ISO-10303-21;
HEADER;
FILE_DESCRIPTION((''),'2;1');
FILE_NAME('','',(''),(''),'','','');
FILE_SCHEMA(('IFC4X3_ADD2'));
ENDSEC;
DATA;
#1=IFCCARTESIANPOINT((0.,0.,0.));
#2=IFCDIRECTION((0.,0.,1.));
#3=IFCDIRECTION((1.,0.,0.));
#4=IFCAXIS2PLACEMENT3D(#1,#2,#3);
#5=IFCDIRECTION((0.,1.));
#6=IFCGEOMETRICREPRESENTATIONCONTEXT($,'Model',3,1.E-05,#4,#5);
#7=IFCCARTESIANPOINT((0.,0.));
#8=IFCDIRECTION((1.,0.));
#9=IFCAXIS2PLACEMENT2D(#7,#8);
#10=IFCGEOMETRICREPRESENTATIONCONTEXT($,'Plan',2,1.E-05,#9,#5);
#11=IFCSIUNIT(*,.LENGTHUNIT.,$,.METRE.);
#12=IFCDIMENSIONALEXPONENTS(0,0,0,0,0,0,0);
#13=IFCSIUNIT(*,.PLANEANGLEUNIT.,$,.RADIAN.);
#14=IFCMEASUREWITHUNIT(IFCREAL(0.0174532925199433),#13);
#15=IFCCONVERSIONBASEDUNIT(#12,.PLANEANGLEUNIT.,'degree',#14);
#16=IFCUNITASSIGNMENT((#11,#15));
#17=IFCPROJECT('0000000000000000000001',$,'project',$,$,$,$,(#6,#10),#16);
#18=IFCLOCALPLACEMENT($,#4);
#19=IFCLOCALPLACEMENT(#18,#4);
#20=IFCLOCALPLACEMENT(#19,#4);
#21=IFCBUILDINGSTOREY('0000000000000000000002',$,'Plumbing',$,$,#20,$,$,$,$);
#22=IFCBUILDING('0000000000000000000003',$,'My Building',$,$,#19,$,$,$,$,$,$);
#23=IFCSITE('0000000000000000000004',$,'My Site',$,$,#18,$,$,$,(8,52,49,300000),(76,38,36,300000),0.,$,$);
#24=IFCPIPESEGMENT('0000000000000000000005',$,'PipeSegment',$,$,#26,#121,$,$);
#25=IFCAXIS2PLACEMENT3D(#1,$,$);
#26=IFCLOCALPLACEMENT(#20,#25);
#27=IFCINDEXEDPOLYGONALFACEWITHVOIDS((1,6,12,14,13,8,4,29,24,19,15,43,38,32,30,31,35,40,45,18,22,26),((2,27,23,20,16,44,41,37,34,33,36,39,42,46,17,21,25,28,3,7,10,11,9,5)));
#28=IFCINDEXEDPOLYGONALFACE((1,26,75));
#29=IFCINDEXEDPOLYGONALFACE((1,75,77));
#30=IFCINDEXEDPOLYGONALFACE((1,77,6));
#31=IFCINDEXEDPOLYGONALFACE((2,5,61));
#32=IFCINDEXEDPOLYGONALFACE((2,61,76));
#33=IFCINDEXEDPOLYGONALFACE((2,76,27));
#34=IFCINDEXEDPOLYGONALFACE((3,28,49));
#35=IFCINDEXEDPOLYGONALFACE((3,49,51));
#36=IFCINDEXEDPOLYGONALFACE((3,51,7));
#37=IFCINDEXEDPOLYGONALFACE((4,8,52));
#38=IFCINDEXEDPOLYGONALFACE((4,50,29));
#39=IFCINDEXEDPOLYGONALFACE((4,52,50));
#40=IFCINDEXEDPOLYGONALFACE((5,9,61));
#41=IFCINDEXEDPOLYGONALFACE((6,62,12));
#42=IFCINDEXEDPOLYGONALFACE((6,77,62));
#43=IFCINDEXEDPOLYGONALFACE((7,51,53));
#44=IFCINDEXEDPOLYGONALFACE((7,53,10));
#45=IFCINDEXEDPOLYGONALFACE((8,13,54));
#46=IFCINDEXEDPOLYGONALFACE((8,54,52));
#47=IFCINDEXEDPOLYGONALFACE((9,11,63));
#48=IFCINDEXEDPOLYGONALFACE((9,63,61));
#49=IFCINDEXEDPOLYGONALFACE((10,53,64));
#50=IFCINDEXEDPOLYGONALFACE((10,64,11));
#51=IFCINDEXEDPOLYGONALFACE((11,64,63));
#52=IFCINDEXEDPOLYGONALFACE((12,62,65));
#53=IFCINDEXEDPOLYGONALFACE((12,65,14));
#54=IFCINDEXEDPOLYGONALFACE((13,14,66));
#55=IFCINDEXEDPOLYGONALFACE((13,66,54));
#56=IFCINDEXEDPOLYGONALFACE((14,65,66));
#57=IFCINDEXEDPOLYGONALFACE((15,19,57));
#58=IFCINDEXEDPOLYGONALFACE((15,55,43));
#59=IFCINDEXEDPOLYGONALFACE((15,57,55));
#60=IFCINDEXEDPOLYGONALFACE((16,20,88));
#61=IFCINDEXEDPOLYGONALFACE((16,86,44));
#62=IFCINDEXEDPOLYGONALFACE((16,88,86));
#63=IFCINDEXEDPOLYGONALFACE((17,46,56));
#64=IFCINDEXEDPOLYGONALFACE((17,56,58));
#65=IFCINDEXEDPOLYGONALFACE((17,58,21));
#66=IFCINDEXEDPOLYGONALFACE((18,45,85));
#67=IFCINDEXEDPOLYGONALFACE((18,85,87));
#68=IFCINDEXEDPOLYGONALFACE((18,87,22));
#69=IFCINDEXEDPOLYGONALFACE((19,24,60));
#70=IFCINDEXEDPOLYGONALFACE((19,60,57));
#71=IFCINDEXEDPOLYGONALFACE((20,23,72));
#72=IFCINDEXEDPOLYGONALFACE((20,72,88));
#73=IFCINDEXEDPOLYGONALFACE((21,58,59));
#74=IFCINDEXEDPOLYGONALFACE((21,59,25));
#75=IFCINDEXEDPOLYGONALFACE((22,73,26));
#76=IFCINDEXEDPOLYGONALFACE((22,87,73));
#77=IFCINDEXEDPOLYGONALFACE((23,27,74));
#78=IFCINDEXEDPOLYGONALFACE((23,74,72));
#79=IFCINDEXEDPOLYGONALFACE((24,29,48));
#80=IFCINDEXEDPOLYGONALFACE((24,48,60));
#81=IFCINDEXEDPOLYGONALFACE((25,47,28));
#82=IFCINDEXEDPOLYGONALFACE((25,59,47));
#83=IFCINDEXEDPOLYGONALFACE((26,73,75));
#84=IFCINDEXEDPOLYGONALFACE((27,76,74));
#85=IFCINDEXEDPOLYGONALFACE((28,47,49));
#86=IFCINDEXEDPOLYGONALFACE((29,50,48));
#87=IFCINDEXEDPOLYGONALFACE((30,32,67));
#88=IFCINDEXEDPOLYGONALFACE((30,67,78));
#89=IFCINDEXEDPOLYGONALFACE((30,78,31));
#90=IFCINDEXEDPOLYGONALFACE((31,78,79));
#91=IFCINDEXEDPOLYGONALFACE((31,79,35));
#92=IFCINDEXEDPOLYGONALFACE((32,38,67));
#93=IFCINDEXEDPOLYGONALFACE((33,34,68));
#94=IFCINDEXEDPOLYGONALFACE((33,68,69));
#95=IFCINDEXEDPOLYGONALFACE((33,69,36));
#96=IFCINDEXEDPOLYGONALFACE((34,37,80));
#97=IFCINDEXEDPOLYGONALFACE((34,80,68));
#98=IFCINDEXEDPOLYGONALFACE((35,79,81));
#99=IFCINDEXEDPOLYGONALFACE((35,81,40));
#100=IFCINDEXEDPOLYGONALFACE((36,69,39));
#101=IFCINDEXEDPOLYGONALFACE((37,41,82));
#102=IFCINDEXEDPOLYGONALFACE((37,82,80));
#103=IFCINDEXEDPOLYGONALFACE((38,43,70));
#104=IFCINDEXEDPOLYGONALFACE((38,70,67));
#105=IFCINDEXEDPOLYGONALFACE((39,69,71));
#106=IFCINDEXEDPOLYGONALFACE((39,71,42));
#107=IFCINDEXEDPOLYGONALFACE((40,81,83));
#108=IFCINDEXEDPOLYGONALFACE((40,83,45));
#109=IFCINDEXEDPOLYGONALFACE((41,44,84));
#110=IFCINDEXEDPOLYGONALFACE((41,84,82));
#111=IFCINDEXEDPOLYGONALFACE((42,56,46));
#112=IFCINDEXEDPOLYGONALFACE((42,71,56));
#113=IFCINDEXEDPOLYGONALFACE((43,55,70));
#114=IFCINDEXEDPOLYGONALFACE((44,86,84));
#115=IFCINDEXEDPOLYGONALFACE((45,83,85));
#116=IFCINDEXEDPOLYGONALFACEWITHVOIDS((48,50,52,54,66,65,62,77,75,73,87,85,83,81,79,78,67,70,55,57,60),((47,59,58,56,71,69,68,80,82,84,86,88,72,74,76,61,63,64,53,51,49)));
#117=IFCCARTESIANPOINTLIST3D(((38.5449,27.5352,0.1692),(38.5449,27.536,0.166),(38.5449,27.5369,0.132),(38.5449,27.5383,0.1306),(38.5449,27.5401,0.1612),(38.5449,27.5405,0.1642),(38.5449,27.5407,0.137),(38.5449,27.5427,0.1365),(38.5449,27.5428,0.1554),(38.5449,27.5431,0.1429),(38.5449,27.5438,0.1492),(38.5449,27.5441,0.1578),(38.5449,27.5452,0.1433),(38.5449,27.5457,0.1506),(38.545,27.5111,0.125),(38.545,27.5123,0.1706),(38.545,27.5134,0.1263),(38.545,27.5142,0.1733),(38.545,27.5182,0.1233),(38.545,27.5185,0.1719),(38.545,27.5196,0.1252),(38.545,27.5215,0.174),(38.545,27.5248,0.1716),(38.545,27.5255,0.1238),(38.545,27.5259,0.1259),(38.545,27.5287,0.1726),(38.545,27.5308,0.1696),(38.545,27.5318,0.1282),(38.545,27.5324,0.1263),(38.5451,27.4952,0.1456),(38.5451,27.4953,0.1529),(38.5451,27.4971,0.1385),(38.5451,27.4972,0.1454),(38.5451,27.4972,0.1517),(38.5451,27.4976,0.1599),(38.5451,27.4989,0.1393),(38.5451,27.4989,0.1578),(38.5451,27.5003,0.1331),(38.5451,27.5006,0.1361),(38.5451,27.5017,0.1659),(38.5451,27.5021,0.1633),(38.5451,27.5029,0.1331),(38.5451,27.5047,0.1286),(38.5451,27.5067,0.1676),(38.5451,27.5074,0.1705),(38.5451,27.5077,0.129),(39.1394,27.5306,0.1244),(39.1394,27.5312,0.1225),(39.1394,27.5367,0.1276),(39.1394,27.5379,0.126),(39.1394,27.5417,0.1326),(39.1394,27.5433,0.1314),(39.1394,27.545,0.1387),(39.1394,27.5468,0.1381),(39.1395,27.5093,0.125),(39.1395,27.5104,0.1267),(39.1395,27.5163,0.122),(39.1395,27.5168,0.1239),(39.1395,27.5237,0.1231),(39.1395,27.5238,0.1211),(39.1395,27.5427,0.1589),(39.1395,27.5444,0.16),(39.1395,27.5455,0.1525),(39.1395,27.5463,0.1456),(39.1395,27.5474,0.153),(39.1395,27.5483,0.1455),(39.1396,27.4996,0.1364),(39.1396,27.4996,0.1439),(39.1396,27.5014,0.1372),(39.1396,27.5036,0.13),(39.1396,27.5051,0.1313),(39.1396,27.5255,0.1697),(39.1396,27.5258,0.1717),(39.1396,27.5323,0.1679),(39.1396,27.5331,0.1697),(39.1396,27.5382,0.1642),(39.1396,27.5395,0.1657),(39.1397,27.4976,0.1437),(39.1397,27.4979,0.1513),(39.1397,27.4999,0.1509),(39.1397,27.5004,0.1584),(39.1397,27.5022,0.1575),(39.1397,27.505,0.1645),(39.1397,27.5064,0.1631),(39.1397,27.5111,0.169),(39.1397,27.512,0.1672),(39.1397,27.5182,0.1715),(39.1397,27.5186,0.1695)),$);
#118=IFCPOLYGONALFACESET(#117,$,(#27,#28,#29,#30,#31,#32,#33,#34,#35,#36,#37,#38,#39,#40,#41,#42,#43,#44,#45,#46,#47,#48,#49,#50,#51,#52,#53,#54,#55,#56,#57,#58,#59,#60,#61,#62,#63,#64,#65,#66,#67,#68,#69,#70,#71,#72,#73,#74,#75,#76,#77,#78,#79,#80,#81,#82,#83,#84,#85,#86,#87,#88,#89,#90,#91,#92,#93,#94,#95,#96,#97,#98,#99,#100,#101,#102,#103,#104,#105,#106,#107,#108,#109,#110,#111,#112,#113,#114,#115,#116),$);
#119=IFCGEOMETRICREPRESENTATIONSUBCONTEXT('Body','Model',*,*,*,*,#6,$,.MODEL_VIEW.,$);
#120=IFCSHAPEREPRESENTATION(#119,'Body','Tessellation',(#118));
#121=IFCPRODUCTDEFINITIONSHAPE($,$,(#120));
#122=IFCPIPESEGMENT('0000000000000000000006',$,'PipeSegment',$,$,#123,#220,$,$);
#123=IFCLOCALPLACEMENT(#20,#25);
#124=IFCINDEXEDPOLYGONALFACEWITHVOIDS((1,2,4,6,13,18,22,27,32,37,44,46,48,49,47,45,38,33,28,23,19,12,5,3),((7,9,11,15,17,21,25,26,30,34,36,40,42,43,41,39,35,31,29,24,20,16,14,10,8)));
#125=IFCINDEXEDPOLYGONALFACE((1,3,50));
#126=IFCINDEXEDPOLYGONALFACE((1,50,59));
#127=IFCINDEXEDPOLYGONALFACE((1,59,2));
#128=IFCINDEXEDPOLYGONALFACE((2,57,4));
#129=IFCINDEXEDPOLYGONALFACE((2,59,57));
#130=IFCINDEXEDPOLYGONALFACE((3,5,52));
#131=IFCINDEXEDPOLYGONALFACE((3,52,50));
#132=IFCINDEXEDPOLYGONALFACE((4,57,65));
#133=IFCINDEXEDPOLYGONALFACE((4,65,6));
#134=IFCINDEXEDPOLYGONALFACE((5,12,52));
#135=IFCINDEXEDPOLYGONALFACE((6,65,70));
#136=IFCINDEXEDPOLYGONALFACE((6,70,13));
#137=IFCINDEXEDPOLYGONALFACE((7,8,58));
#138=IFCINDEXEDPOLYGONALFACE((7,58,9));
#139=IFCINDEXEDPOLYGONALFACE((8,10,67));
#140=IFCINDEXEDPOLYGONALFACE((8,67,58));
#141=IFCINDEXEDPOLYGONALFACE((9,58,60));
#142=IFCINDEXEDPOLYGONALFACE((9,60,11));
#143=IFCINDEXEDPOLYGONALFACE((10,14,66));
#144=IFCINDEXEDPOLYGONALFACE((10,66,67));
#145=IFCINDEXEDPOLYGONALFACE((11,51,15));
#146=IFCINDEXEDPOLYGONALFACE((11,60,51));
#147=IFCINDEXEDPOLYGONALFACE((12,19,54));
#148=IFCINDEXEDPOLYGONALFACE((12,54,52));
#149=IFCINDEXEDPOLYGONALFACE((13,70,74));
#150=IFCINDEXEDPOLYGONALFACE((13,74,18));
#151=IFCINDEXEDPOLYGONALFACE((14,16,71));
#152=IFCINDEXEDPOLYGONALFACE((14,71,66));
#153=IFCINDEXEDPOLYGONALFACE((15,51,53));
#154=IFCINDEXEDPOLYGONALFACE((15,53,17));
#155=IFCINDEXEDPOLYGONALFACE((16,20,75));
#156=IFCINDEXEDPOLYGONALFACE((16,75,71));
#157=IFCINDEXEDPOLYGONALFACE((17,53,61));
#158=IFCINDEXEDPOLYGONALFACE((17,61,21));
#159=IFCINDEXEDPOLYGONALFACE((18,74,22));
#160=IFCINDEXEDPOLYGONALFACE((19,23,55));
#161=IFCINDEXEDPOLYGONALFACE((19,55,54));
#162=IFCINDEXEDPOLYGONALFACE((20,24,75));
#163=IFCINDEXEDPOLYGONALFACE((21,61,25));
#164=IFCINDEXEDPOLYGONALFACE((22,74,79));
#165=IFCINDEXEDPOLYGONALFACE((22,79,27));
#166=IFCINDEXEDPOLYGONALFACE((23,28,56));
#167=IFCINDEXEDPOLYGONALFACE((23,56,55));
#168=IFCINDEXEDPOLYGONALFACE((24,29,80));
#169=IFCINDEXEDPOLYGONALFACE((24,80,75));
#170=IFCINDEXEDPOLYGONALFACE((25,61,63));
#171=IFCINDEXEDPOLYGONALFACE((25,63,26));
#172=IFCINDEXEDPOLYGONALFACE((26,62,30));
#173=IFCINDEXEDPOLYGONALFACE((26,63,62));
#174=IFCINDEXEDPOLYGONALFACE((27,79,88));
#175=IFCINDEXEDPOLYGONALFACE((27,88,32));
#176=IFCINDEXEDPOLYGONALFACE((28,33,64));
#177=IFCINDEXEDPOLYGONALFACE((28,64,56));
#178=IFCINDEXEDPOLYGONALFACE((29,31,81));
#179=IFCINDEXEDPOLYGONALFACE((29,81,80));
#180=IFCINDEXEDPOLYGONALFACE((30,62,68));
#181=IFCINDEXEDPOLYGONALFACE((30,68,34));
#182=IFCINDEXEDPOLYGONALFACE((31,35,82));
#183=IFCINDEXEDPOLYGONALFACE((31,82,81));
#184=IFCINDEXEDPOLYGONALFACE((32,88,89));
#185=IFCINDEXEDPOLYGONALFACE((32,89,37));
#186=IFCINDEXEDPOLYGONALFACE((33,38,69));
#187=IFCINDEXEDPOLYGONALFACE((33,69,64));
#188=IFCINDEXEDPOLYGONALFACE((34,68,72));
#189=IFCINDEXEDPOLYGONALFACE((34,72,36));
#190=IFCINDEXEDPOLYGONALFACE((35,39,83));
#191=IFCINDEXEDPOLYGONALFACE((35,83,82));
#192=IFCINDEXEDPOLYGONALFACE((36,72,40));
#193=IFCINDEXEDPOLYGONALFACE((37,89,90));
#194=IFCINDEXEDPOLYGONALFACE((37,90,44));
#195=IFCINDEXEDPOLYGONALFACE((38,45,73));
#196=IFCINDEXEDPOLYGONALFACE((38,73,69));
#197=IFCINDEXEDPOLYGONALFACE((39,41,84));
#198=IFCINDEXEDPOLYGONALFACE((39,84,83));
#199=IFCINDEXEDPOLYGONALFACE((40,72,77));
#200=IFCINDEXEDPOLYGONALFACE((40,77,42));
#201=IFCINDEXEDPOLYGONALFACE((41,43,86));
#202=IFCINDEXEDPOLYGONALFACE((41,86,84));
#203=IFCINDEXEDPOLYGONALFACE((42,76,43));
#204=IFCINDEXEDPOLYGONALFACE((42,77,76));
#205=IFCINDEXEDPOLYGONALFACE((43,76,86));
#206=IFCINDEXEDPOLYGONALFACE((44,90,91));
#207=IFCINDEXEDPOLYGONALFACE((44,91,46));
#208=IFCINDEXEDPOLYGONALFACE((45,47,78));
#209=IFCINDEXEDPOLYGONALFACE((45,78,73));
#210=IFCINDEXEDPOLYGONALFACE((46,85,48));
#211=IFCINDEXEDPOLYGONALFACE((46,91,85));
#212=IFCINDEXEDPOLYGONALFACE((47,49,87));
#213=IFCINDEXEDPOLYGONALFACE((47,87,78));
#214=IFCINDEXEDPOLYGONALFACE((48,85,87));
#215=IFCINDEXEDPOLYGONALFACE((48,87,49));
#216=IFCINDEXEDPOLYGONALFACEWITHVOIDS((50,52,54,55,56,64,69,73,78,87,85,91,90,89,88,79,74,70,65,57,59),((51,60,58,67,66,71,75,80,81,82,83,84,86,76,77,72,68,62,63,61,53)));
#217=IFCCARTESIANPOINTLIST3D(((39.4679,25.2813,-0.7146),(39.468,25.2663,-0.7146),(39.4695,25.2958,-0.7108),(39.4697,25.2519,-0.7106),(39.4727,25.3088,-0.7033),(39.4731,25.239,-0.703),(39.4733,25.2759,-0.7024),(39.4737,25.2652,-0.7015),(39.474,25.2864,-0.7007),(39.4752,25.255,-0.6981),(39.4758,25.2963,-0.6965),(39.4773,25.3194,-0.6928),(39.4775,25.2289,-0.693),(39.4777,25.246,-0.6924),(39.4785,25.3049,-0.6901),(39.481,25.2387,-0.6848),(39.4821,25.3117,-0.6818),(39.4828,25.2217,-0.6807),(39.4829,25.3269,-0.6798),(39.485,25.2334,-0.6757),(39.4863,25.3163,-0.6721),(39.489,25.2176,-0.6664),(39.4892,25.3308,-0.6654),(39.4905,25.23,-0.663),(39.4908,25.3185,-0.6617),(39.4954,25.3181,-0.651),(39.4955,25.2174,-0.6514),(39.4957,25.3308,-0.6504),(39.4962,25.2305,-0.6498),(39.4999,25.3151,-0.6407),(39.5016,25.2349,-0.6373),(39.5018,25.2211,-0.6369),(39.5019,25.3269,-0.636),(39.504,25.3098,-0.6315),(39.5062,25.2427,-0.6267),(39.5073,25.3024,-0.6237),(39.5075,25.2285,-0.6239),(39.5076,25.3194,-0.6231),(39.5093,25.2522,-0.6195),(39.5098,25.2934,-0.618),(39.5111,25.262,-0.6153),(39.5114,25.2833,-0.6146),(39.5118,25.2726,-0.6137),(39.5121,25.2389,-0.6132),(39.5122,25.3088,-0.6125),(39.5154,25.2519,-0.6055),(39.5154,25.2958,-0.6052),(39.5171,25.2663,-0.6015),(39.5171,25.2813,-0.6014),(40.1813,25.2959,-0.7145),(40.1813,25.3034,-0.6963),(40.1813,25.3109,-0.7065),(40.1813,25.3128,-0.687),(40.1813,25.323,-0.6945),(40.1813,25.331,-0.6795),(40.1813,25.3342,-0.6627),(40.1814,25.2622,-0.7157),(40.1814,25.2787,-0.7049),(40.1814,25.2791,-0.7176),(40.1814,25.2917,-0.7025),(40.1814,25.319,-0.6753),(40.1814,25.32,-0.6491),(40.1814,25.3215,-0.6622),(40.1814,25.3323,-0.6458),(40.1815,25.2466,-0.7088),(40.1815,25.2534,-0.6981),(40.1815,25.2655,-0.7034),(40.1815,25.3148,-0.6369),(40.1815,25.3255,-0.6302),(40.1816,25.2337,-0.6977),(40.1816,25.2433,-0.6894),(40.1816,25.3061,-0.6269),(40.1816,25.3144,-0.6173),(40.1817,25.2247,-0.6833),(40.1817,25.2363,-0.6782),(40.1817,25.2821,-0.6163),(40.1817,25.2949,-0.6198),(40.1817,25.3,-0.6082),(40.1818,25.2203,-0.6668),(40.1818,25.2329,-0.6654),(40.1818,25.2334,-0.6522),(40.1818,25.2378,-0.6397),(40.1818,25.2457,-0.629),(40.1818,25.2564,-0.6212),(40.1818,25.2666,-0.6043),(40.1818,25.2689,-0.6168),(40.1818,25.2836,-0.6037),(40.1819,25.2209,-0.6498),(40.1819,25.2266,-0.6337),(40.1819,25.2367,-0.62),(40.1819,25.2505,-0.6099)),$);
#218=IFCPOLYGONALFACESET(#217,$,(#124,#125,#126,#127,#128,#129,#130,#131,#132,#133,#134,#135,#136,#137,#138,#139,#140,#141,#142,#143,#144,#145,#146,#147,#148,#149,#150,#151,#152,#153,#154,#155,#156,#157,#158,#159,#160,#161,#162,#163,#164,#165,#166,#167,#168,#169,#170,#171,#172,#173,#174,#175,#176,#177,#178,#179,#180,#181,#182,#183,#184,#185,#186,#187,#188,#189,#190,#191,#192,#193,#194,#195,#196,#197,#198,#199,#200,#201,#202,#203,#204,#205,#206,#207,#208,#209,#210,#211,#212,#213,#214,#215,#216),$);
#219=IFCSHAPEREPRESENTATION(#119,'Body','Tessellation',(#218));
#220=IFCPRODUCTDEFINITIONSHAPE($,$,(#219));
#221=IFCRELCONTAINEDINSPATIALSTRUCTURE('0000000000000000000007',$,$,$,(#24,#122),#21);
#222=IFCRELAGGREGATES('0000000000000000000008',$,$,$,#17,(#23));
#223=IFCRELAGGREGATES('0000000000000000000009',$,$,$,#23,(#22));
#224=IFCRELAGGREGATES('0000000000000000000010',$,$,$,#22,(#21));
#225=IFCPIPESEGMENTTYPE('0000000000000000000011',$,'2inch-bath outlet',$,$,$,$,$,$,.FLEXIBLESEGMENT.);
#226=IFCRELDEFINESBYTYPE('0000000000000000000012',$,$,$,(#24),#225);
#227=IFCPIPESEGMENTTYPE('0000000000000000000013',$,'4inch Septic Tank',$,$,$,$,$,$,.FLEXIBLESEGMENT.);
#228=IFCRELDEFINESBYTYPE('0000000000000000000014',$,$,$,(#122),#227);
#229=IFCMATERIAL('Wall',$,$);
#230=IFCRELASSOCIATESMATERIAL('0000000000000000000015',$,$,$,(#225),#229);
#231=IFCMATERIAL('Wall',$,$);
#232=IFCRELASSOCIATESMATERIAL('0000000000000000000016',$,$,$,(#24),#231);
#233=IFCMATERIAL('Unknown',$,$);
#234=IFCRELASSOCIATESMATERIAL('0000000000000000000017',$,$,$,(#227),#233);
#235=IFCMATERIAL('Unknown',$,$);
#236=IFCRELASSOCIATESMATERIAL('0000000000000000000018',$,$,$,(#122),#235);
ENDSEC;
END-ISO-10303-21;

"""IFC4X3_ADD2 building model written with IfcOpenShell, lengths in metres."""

from ifc_helpers import new_model, entity, si_unit, converted_unit, direction, frame, origin_with_axes, origin_2d_with_axis, place, context, subcontext, project, spatial, hollow_circle, extrude, clip, halfspace, material, material_profile, profile_set, profile_usage, type_object, element, save


model = new_model("IFC4X3_ADD2")

# Units and contexts
model_context = context("Model", 3, precision=1e-05, world=origin_with_axes(), true_north=direction((0.0, 1.0)))
plan_context = context("Plan", 2, precision=1e-05, world=origin_2d_with_axis(), true_north=direction((0.0, 1.0)))
body_context = subcontext(model_context, "Body", "Model", "MODEL_VIEW")
ifc_project = project(units=[si_unit("LENGTHUNIT", "METRE"), converted_unit("PLANEANGLEUNIT", "degree", entity("IfcReal", 0.0174532925199433), si_unit("PLANEANGLEUNIT", "RADIAN"), dimensions=[0, 0, 0, 0, 0, 0, 0])], contexts=[model_context, plan_context])

# Site, building, storey
site_placement = place(None, origin_with_axes())
site = spatial("IfcSite", under=ifc_project, at=site_placement, Name="My Site", RefLatitude=(8, 52, 49, 300000), RefLongitude=(76, 38, 36, 300000), RefElevation=0.0)
building_placement = place(site_placement, origin_with_axes())
building = spatial("IfcBuilding", under=site, at=building_placement, Name="My Building")
storey_placement = place(building_placement, origin_with_axes())
storey = spatial("IfcBuildingStorey", under=building, at=storey_placement, Name="Plumbing")

# Pipe segments
ifc_material_1 = material(Name="Wall")
ifc_material_profile_1 = material_profile(ifc_material_1, hollow_circle(Radius=0.0254, WallThickness=0.002))
ifc_profile_set_1 = profile_set([ifc_material_profile_1], Name="graywater")
ifc_material_2 = material(Name="Wall")
ifc_material_profile_2 = material_profile(ifc_material_2, hollow_circle(Radius=0.0254, WallThickness=0.002))
ifc_profile_set_2 = profile_set([ifc_material_profile_2], Name="graywater")
pipe_segment_type_1 = type_object("IfcPipeSegmentType", Name="2inch-bath outlet", PredefinedType="FLEXIBLESEGMENT", material=ifc_profile_set_2)
ifc_profile_usage_1 = profile_usage(ifc_profile_set_1, cardinal=5)
pipe_segment_1_placement = place(storey_placement, frame((39.1396, 27.5229, 0.1465), z_axis=(-0.999985, -0.004219, 0.003595), x_axis=(0.002438, -0.917305, -0.398179)))
element("IfcPipeSegment", 1, at=pipe_segment_1_placement, inside=storey, type_object=pipe_segment_type_1, material=ifc_profile_usage_1, Name="PipeSegment", context=body_context, shape_type="Clipping", body=[
    clip(extrude(hollow_circle(Radius=0.0254, WallThickness=0.002), origin_with_axes(), (0.0, 0.0, 1.0), 0.6454), halfspace(frame((-0.1342, -0.0618, 0.5945), z_axis=(0.001402, -0.00331, 0.999994), x_axis=(-0.999999, 0.0, 0.001402)), False)),
])
ifc_material_3 = material(Name="Unknown")
ifc_material_profile_3 = material_profile(ifc_material_3, hollow_circle(Radius=0.0571, WallThickness=0.0127))
ifc_profile_set_3 = profile_set([ifc_material_profile_3], Name="blackwater")
ifc_material_4 = material(Name="Unknown")
ifc_material_profile_4 = material_profile(ifc_material_4, hollow_circle(Radius=0.0571, WallThickness=0.0127))
ifc_profile_set_4 = profile_set([ifc_material_profile_4], Name="blackwater")
pipe_segment_type_2 = type_object("IfcPipeSegmentType", Name="4inch Septic Tank", PredefinedType="FLEXIBLESEGMENT", material=ifc_profile_set_4)
ifc_profile_usage_2 = profile_usage(ifc_profile_set_3, cardinal=5)
pipe_segment_2_placement = place(storey_placement, frame((40.1816, 25.2771, -0.6605), z_axis=(-0.999985, -0.004219, 0.003595), x_axis=(0.002438, -0.917305, -0.398179)))
element("IfcPipeSegment", 2, at=pipe_segment_2_placement, inside=storey, type_object=pipe_segment_type_2, material=ifc_profile_usage_2, Name="PipeSegment", context=body_context, shape_type="Clipping", body=[
    clip(extrude(hollow_circle(Radius=0.0571, WallThickness=0.0127), origin_with_axes(), (0.0, 0.0, 1.0), 0.8034), halfspace(frame((-2.0398, -0.8753, 0.6816), z_axis=(-0.158546, 0.361655, 0.918732), x_axis=(0.915857, 0.401504, 0.0)), False)),
])

save(model, "model.ifc")
